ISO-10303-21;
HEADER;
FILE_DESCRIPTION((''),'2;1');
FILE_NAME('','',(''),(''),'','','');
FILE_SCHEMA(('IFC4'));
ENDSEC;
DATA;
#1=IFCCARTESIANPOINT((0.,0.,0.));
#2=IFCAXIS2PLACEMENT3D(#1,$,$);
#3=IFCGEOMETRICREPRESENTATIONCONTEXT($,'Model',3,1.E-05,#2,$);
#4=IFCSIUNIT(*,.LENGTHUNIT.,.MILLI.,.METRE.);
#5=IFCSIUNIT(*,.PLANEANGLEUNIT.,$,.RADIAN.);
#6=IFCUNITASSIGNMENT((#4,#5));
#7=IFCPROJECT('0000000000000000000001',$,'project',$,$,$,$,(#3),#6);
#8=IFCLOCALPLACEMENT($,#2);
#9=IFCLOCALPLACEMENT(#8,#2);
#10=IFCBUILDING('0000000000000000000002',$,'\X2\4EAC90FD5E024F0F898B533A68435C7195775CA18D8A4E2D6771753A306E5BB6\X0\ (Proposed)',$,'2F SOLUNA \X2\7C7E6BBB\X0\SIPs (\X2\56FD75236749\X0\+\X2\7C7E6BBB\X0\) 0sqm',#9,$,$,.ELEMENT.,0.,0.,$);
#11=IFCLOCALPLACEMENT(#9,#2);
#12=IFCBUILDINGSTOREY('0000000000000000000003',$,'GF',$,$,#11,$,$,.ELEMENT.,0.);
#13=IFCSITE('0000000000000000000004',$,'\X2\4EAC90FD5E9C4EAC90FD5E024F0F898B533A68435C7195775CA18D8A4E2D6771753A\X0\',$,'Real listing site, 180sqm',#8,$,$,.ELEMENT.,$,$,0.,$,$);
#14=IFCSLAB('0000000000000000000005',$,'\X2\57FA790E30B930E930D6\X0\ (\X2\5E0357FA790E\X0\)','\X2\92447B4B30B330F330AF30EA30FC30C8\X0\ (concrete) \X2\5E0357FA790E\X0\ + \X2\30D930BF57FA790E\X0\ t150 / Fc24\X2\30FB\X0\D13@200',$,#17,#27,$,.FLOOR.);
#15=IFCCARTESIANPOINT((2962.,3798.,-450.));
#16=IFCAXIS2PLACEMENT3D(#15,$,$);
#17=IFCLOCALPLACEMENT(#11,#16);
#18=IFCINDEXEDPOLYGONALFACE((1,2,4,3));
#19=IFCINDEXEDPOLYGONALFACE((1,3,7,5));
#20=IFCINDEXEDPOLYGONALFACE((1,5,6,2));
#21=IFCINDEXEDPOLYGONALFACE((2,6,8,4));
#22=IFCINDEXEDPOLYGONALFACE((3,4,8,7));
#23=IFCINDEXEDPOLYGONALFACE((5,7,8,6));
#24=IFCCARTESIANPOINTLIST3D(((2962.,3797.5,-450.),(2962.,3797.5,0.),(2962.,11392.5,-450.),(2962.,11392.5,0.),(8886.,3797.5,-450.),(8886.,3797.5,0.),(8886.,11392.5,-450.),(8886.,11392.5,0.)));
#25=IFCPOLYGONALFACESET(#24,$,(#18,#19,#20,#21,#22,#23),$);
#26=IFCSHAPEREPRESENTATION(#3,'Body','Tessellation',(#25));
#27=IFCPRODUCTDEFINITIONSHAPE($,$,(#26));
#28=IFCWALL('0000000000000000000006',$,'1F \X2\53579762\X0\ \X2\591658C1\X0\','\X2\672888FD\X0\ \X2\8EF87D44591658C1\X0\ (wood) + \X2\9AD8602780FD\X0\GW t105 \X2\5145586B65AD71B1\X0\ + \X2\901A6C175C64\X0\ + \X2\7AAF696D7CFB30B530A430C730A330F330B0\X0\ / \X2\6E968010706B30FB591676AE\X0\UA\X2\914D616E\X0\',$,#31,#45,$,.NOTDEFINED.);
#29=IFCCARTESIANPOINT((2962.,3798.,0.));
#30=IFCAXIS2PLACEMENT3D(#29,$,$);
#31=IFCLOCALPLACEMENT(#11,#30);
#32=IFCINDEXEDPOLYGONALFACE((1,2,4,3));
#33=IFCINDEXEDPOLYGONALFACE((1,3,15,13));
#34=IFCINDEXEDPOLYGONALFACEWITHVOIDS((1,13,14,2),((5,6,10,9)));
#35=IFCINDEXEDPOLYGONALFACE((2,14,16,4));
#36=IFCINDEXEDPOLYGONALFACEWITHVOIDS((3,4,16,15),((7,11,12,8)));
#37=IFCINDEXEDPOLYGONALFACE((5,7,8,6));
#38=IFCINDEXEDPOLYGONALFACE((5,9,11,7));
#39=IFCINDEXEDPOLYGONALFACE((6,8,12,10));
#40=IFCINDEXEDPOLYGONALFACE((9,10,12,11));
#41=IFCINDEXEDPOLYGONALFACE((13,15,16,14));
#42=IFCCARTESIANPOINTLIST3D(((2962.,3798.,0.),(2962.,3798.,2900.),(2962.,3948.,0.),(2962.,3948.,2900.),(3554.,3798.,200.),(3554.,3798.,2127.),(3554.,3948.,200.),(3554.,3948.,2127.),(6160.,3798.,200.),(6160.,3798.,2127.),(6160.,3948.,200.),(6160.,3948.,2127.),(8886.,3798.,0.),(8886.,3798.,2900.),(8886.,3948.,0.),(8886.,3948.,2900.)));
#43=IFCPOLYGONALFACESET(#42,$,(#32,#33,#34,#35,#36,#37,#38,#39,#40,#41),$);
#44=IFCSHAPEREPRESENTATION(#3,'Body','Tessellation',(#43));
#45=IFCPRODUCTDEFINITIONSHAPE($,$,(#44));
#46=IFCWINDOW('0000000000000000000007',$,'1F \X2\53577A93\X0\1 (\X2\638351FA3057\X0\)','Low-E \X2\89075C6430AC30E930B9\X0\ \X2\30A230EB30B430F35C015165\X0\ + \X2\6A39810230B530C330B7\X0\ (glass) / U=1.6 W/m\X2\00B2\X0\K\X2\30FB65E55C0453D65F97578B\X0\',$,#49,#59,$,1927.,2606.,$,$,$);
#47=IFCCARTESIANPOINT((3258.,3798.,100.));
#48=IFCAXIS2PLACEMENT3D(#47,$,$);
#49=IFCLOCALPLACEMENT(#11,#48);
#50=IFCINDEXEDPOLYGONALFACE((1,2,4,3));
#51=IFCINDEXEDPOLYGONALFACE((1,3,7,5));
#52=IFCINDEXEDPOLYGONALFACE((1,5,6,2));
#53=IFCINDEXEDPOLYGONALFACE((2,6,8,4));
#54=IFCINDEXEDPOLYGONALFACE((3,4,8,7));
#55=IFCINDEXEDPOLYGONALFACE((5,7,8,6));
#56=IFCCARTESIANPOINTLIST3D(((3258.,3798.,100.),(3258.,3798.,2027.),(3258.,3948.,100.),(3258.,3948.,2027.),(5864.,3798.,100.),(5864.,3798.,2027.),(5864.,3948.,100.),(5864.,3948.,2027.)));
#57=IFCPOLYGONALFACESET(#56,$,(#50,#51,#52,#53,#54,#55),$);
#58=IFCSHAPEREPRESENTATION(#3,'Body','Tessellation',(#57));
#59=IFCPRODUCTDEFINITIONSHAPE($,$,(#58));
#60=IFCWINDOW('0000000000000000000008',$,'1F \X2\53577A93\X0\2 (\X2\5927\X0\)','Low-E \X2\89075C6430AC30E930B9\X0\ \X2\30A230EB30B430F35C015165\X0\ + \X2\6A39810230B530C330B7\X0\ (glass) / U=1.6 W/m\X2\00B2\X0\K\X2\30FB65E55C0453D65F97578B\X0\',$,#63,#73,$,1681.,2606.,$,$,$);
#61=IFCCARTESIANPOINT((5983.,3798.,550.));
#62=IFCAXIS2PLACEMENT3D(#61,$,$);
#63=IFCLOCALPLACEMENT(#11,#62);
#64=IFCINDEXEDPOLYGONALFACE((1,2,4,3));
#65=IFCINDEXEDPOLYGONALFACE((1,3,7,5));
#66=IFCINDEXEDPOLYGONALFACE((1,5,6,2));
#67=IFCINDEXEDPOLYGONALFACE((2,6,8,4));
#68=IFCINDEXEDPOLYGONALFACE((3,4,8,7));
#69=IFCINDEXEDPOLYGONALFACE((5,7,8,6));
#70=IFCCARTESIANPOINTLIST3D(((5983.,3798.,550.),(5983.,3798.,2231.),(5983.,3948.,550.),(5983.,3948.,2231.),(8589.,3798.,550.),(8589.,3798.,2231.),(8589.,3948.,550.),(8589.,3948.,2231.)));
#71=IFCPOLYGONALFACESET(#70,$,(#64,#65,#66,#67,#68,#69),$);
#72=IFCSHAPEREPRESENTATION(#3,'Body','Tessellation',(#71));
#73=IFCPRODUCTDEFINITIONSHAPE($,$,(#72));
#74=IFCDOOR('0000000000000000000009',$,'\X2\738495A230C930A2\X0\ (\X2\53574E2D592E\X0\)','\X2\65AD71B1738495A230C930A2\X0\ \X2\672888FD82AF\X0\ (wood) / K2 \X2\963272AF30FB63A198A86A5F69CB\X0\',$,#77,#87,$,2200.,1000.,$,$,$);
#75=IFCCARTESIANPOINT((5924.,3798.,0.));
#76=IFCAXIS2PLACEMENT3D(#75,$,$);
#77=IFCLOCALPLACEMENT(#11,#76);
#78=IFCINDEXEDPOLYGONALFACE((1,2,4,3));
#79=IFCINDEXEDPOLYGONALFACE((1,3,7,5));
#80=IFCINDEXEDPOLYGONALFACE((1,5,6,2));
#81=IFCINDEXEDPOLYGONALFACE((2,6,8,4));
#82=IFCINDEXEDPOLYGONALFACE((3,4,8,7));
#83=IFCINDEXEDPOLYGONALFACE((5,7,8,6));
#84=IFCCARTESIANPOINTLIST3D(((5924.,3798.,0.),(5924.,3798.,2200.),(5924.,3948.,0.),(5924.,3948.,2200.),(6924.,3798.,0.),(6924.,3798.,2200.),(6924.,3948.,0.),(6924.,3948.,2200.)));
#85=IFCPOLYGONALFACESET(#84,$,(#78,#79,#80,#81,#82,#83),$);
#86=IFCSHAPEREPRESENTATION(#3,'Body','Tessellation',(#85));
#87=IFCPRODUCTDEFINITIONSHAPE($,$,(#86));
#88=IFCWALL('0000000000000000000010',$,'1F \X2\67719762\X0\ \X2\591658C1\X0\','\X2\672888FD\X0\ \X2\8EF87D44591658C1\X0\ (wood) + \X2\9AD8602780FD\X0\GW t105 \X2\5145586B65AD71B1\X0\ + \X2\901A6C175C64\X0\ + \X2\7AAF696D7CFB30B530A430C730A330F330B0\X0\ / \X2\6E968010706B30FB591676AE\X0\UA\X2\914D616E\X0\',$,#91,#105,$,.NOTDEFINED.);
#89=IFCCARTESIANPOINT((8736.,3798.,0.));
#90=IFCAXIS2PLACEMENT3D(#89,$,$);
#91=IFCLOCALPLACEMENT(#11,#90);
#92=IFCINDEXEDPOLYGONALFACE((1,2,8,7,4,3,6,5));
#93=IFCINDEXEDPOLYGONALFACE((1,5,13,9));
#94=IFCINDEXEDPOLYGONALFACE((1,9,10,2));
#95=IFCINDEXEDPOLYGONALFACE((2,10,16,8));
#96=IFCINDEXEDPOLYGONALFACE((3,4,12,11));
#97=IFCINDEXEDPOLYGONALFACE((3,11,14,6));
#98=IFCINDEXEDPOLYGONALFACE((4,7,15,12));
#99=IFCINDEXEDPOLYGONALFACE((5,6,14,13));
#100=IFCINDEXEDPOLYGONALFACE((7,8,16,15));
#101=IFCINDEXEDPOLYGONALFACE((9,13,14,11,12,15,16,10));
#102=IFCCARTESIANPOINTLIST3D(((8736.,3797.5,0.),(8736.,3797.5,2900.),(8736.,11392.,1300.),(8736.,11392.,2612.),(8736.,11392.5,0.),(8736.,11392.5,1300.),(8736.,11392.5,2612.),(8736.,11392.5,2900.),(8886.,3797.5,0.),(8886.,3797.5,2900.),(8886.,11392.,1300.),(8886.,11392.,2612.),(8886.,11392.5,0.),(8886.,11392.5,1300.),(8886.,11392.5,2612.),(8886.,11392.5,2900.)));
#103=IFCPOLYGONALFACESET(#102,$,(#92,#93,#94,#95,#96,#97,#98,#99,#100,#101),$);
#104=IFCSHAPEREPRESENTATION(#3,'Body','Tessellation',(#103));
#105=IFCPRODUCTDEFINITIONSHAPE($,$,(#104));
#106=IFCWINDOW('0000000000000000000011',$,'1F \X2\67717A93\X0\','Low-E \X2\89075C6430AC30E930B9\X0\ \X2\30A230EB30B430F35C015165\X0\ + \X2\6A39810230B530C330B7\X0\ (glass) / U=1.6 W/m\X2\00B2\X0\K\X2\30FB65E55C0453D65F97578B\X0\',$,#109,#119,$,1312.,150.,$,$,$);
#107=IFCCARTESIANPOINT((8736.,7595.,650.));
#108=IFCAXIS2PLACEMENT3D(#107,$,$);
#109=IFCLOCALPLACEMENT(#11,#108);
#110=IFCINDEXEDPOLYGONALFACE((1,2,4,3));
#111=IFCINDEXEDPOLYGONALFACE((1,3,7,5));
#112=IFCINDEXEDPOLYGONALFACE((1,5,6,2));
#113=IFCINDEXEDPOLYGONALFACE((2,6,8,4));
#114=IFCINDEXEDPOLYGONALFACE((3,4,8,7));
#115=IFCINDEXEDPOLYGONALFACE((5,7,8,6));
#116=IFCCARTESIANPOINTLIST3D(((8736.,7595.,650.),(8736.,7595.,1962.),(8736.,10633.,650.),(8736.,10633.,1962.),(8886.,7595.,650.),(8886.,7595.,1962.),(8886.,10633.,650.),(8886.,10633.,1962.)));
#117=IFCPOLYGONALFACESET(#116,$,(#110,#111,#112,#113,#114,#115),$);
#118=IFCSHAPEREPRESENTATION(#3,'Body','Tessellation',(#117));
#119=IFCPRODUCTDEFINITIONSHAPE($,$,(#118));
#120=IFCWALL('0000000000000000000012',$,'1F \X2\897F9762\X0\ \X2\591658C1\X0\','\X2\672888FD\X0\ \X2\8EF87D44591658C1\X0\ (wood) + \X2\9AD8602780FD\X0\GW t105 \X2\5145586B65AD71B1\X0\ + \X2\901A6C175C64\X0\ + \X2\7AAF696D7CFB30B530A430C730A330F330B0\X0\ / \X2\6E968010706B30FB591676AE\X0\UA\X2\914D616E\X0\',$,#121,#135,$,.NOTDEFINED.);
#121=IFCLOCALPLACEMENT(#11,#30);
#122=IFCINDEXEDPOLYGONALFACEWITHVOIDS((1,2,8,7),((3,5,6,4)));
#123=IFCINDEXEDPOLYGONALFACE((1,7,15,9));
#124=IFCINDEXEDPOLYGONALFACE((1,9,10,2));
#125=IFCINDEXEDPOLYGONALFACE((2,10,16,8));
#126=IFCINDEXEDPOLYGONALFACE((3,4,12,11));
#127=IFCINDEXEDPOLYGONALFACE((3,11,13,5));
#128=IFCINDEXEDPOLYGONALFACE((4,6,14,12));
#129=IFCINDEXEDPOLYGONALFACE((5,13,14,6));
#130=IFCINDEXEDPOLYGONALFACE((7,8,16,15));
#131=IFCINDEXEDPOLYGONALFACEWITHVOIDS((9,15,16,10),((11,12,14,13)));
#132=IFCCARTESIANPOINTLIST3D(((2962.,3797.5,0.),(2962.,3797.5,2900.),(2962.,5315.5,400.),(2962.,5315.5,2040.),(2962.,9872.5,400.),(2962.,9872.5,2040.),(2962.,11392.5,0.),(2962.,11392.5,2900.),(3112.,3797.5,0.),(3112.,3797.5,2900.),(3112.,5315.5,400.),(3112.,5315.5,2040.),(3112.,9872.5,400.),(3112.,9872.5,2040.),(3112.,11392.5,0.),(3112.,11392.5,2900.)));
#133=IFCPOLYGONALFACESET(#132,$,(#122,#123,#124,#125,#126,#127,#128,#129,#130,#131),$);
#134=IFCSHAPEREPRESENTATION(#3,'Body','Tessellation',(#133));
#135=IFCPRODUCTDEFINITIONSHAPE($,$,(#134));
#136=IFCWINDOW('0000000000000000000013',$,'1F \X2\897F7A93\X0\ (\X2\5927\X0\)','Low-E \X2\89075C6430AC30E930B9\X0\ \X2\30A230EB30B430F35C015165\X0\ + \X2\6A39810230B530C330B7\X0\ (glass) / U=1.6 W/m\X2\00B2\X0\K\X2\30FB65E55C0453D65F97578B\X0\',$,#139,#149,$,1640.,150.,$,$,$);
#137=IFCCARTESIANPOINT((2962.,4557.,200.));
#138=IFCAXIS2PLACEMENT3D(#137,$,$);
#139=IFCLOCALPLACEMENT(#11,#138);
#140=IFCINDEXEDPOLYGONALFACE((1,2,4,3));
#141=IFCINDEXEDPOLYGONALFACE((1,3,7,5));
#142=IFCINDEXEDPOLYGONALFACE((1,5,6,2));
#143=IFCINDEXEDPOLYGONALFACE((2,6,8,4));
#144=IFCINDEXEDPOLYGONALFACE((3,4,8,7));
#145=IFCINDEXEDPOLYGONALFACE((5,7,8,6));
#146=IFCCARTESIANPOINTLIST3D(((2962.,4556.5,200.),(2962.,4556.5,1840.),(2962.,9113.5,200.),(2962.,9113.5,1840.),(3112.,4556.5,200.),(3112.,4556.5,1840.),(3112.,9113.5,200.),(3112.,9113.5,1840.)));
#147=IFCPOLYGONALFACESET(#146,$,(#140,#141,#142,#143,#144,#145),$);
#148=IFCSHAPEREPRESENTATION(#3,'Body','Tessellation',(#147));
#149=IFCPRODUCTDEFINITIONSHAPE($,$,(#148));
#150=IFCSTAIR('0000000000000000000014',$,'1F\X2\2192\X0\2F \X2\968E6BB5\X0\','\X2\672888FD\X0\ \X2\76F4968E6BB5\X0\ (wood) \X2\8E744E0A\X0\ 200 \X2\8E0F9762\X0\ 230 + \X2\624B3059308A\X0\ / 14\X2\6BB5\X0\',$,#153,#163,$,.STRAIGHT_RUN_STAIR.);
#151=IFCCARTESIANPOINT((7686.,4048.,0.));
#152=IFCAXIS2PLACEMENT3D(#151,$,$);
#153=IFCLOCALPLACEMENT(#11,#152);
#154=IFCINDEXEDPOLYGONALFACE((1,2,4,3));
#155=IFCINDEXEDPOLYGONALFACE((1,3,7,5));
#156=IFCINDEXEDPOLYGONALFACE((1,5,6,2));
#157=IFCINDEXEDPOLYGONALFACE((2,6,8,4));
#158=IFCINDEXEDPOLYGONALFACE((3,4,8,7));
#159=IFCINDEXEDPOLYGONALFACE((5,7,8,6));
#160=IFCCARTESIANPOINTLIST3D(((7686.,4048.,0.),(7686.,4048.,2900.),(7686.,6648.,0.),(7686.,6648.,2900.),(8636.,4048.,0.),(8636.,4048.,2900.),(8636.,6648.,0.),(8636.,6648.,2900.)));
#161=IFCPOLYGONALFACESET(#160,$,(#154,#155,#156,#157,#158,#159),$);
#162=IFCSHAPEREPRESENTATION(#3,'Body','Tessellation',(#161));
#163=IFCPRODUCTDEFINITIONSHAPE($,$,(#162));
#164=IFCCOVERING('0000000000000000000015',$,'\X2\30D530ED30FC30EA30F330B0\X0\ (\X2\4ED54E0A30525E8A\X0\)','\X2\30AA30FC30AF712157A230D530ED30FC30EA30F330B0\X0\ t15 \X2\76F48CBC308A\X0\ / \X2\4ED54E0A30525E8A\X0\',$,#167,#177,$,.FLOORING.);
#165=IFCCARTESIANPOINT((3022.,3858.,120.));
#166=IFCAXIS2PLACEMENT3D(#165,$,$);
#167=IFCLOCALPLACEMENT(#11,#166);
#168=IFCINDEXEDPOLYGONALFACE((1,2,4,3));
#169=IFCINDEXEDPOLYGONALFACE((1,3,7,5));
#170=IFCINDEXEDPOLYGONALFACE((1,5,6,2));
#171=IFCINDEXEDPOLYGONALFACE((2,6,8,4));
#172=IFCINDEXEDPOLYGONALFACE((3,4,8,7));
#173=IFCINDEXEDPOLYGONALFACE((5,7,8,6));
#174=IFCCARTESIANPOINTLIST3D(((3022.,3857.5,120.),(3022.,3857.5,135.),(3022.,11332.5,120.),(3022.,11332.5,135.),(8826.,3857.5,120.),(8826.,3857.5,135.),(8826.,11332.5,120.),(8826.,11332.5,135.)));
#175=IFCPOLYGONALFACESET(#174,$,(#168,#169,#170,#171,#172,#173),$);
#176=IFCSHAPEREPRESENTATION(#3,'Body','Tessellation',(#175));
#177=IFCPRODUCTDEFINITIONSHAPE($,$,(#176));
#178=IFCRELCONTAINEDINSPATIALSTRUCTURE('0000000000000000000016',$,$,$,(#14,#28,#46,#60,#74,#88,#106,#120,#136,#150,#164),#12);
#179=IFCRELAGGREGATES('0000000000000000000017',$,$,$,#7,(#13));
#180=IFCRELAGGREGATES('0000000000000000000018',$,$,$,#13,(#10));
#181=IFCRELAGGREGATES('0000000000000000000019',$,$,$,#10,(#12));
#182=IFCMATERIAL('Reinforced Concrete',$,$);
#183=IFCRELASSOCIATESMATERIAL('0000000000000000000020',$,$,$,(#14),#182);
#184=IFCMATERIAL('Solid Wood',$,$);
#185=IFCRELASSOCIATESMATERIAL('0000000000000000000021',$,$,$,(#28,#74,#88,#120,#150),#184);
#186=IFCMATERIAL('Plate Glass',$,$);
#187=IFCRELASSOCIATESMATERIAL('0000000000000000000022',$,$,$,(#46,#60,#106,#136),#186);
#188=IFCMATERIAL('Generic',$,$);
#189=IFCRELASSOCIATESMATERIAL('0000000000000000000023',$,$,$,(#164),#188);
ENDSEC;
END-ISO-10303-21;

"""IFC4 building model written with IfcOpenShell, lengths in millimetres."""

from ifc_helpers import new_model, si_unit, frame, frame_2d, origin, place, context, project, spatial, rectangle, extrude, material, element, fill, save


model = new_model("IFC4")

# Units and contexts
model_context = context("Model", 3, precision=1e-05, world=origin())
ifc_project = project(units=[si_unit("LENGTHUNIT", "METRE", prefix="MILLI"), si_unit("PLANEANGLEUNIT", "RADIAN")], contexts=[model_context])

# Site, building, storey
site_placement = place(None, origin())
site = spatial("IfcSite", under=ifc_project, at=site_placement, Name="京都府京都市伏見区桃山長岡越中東町", ObjectType="Real listing site, 180sqm", CompositionType="ELEMENT", RefElevation=0.0)
building_placement = place(site_placement, origin())
building = spatial("IfcBuilding", under=site, at=building_placement, Name="京都市伏見区桃山長岡越中東町の家 (Proposed)", ObjectType="2F SOLUNA 籾殻SIPs (国産杉+籾殻) 0sqm", CompositionType="ELEMENT", ElevationOfRefHeight=0.0, ElevationOfTerrain=0.0)
storey_placement = place(building_placement, origin())
storey = spatial("IfcBuildingStorey", under=building, at=storey_placement, Name="GF", CompositionType="ELEMENT", Elevation=0.0)

# Slab
ifc_material_1 = material(Name="Reinforced Concrete")
slab_1_placement = place(storey_placement, frame((2962.0, 3798.0, -450.0)))
element("IfcSlab", 1, at=slab_1_placement, inside=storey, material=ifc_material_1, Name="基礎スラブ (布基礎)", Description="鉄筋コンクリート (concrete) 布基礎 + ベタ基礎 t150 / Fc24・D13@200", PredefinedType="FLOOR", context=model_context, shape_type="SweptSolid", body=[
    extrude(rectangle(XDim=5924.0, YDim=7595.0, at=frame_2d((2962.0, 3797.0))), frame((2962.0, 3798.0, -450.0)), (0.0, 0.0, 1.0), 450.0),
])
ifc_material_2 = material(Name="Solid Wood")

# Wall, openings, windows, door
wall_1_placement = place(storey_placement, frame((2962.0, 3798.0, 0.0)))
wall_1 = element("IfcWall", 2, at=wall_1_placement, inside=storey, material=ifc_material_2, Name="1F 南面 外壁", Description="木製 軸組外壁 (wood) + 高性能GW t105 充填断熱 + 通気層 + 窯業系サイディング / 準耐火・外皮UA配慮", PredefinedType="NOTDEFINED", context=model_context, shape_type="SweptSolid", body=[
    extrude(rectangle(XDim=5924.0, YDim=150.0, at=frame_2d((2962.0, 75.0))), frame((2962.0, 3798.0, 0.0)), (0.0, 0.0, 1.0), 2900.0),
])
opening_1_placement = place(storey_placement, frame((3258.0, 3798.0, 100.0)))
opening_1 = element("IfcOpeningElement", 3, at=opening_1_placement, cuts=wall_1, PredefinedType="NOTDEFINED", context=model_context, shape_type="SweptSolid", body=[
    extrude(rectangle(XDim=2606.0, YDim=150.0, at=frame_2d((1303.0, 75.0))), frame((3258.0, 3798.0, 100.0)), (0.0, 0.0, 1.0), 1927.0),
])
opening_2_placement = place(storey_placement, frame((5983.0, 3798.0, 550.0)))
opening_2 = element("IfcOpeningElement", 4, at=opening_2_placement, cuts=wall_1, PredefinedType="NOTDEFINED", context=model_context, shape_type="SweptSolid", body=[
    extrude(rectangle(XDim=2606.0, YDim=150.0, at=frame_2d((1303.0, 75.0))), frame((5983.0, 3798.0, 550.0)), (0.0, 0.0, 1.0), 1681.0),
])
opening_3_placement = place(storey_placement, frame((5924.0, 3798.0, 0.0)))
opening_3 = element("IfcOpeningElement", 5, at=opening_3_placement, cuts=wall_1, PredefinedType="NOTDEFINED", context=model_context, shape_type="SweptSolid", body=[
    extrude(rectangle(XDim=1000.0, YDim=150.0, at=frame_2d((500.0, 75.0))), frame((5924.0, 3798.0, 0.0)), (0.0, 0.0, 1.0), 2200.0),
])
ifc_material_3 = material(Name="Plate Glass")
window_1_placement = place(storey_placement, frame((3258.0, 3798.0, 100.0)))
window_1 = element("IfcWindow", 6, at=window_1_placement, inside=storey, material=ifc_material_3, Name="1F 南窓1 (掃出し)", Description="Low-E 複層ガラス アルゴン封入 + 樹脂サッシ (glass) / U=1.6 W/m²K・日射取得型", OverallHeight=1927.0, OverallWidth=2606.0, context=model_context, shape_type="SweptSolid", body=[
    extrude(rectangle(XDim=2606.0, YDim=150.0, at=frame_2d((1303.0, 75.0))), frame((3258.0, 3798.0, 100.0)), (0.0, 0.0, 1.0), 1927.0),
])
fill(opening_1, window_1)
window_2_placement = place(storey_placement, frame((5983.0, 3798.0, 550.0)))
window_2 = element("IfcWindow", 7, at=window_2_placement, inside=storey, material=ifc_material_3, Name="1F 南窓2 (大)", Description="Low-E 複層ガラス アルゴン封入 + 樹脂サッシ (glass) / U=1.6 W/m²K・日射取得型", OverallHeight=1681.0, OverallWidth=2606.0, context=model_context, shape_type="SweptSolid", body=[
    extrude(rectangle(XDim=2606.0, YDim=150.0, at=frame_2d((1303.0, 75.0))), frame((5983.0, 3798.0, 550.0)), (0.0, 0.0, 1.0), 1681.0),
])
fill(opening_2, window_2)
door_placement = place(storey_placement, frame((5924.0, 3798.0, 0.0)))
door = element("IfcDoor", 8, at=door_placement, inside=storey, material=ifc_material_2, Name="玄関ドア (南中央)", Description="断熱玄関ドア 木製芯 (wood) / K2 防犯・採風機構", OverallHeight=2200.0, OverallWidth=1000.0, context=model_context, shape_type="SweptSolid", body=[
    extrude(rectangle(XDim=1000.0, YDim=150.0, at=frame_2d((500.0, 75.0))), frame((5924.0, 3798.0, 0.0)), (0.0, 0.0, 1.0), 2200.0),
])
fill(opening_3, door)

# Walls, openings, windows
wall_2_placement = place(storey_placement, frame((8736.0, 3798.0, 0.0)))
wall_2 = element("IfcWall", 9, at=wall_2_placement, inside=storey, material=ifc_material_2, Name="1F 東面 外壁", Description="木製 軸組外壁 (wood) + 高性能GW t105 充填断熱 + 通気層 + 窯業系サイディング / 準耐火・外皮UA配慮", PredefinedType="NOTDEFINED", context=model_context, shape_type="SweptSolid", body=[
    extrude(rectangle(XDim=150.0, YDim=7595.0, at=frame_2d((75.0, 3797.0))), frame((8736.0, 3798.0, 0.0)), (0.0, 0.0, 1.0), 2900.0),
])
opening_4_placement = place(storey_placement, frame((8736.0, 7595.0, 650.0)))
opening_4 = element("IfcOpeningElement", 10, at=opening_4_placement, cuts=wall_2, PredefinedType="NOTDEFINED", context=model_context, shape_type="SweptSolid", body=[
    extrude(rectangle(XDim=150.0, YDim=3038.0, at=frame_2d((75.0, 1519.0))), frame((8736.0, 7595.0, 650.0)), (0.0, 0.0, 1.0), 1312.0),
])
window_3_placement = place(storey_placement, frame((8736.0, 7595.0, 650.0)))
window_3 = element("IfcWindow", 11, at=window_3_placement, inside=storey, material=ifc_material_3, Name="1F 東窓", Description="Low-E 複層ガラス アルゴン封入 + 樹脂サッシ (glass) / U=1.6 W/m²K・日射取得型", OverallHeight=1312.0, OverallWidth=150.0, context=model_context, shape_type="SweptSolid", body=[
    extrude(rectangle(XDim=150.0, YDim=3038.0, at=frame_2d((75.0, 1519.0))), frame((8736.0, 7595.0, 650.0)), (0.0, 0.0, 1.0), 1312.0),
])
fill(opening_4, window_3)
wall_3_placement = place(storey_placement, frame((2962.0, 3798.0, 0.0)))
wall_3 = element("IfcWall", 12, at=wall_3_placement, inside=storey, material=ifc_material_2, Name="1F 西面 外壁", Description="木製 軸組外壁 (wood) + 高性能GW t105 充填断熱 + 通気層 + 窯業系サイディング / 準耐火・外皮UA配慮", PredefinedType="NOTDEFINED", context=model_context, shape_type="SweptSolid", body=[
    extrude(rectangle(XDim=150.0, YDim=7595.0, at=frame_2d((75.0, 3797.0))), frame((2962.0, 3798.0, 0.0)), (0.0, 0.0, 1.0), 2900.0),
])
opening_5_placement = place(storey_placement, frame((2962.0, 4557.0, 200.0)))
opening_5 = element("IfcOpeningElement", 13, at=opening_5_placement, cuts=wall_3, PredefinedType="NOTDEFINED", context=model_context, shape_type="SweptSolid", body=[
    extrude(rectangle(XDim=150.0, YDim=4557.0, at=frame_2d((75.0, 2278.0))), frame((2962.0, 4557.0, 200.0)), (0.0, 0.0, 1.0), 1640.0),
])
window_4_placement = place(storey_placement, frame((2962.0, 4557.0, 200.0)))
window_4 = element("IfcWindow", 14, at=window_4_placement, inside=storey, material=ifc_material_3, Name="1F 西窓 (大)", Description="Low-E 複層ガラス アルゴン封入 + 樹脂サッシ (glass) / U=1.6 W/m²K・日射取得型", OverallHeight=1640.0, OverallWidth=150.0, context=model_context, shape_type="SweptSolid", body=[
    extrude(rectangle(XDim=150.0, YDim=4557.0, at=frame_2d((75.0, 2278.0))), frame((2962.0, 4557.0, 200.0)), (0.0, 0.0, 1.0), 1640.0),
])
fill(opening_5, window_4)

# Stair
stair_placement = place(storey_placement, frame((7686.0, 4048.0, 0.0)))
element("IfcStair", 15, at=stair_placement, inside=storey, material=ifc_material_2, Name="1F→2F 階段", Description="木製 直階段 (wood) 蹴上 200 踏面 230 + 手すり / 14段", PredefinedType="STRAIGHT_RUN_STAIR", context=model_context, shape_type="SweptSolid", body=[
    extrude(rectangle(XDim=950.0, YDim=2600.0, at=frame_2d((475.0, 1300.0))), frame((7686.0, 4048.0, 0.0)), (0.0, 0.0, 1.0), 2900.0),
])

# Covering
ifc_material_4 = material(Name="Generic")
covering_placement = place(storey_placement, frame((3022.0, 3858.0, 120.0)))
element("IfcCovering", 16, at=covering_placement, inside=storey, material=ifc_material_4, Name="フローリング (仕上げ床)", Description="オーク無垢フローリング t15 直貼り / 仕上げ床", PredefinedType="FLOORING", context=model_context, shape_type="SweptSolid", body=[
    extrude(rectangle(XDim=5804.0, YDim=7475.0, at=frame_2d((2902.0, 3737.0))), frame((3022.0, 3858.0, 120.0)), (0.0, 0.0, 1.0), 15.0),
])

save(model, "model.ifc")
